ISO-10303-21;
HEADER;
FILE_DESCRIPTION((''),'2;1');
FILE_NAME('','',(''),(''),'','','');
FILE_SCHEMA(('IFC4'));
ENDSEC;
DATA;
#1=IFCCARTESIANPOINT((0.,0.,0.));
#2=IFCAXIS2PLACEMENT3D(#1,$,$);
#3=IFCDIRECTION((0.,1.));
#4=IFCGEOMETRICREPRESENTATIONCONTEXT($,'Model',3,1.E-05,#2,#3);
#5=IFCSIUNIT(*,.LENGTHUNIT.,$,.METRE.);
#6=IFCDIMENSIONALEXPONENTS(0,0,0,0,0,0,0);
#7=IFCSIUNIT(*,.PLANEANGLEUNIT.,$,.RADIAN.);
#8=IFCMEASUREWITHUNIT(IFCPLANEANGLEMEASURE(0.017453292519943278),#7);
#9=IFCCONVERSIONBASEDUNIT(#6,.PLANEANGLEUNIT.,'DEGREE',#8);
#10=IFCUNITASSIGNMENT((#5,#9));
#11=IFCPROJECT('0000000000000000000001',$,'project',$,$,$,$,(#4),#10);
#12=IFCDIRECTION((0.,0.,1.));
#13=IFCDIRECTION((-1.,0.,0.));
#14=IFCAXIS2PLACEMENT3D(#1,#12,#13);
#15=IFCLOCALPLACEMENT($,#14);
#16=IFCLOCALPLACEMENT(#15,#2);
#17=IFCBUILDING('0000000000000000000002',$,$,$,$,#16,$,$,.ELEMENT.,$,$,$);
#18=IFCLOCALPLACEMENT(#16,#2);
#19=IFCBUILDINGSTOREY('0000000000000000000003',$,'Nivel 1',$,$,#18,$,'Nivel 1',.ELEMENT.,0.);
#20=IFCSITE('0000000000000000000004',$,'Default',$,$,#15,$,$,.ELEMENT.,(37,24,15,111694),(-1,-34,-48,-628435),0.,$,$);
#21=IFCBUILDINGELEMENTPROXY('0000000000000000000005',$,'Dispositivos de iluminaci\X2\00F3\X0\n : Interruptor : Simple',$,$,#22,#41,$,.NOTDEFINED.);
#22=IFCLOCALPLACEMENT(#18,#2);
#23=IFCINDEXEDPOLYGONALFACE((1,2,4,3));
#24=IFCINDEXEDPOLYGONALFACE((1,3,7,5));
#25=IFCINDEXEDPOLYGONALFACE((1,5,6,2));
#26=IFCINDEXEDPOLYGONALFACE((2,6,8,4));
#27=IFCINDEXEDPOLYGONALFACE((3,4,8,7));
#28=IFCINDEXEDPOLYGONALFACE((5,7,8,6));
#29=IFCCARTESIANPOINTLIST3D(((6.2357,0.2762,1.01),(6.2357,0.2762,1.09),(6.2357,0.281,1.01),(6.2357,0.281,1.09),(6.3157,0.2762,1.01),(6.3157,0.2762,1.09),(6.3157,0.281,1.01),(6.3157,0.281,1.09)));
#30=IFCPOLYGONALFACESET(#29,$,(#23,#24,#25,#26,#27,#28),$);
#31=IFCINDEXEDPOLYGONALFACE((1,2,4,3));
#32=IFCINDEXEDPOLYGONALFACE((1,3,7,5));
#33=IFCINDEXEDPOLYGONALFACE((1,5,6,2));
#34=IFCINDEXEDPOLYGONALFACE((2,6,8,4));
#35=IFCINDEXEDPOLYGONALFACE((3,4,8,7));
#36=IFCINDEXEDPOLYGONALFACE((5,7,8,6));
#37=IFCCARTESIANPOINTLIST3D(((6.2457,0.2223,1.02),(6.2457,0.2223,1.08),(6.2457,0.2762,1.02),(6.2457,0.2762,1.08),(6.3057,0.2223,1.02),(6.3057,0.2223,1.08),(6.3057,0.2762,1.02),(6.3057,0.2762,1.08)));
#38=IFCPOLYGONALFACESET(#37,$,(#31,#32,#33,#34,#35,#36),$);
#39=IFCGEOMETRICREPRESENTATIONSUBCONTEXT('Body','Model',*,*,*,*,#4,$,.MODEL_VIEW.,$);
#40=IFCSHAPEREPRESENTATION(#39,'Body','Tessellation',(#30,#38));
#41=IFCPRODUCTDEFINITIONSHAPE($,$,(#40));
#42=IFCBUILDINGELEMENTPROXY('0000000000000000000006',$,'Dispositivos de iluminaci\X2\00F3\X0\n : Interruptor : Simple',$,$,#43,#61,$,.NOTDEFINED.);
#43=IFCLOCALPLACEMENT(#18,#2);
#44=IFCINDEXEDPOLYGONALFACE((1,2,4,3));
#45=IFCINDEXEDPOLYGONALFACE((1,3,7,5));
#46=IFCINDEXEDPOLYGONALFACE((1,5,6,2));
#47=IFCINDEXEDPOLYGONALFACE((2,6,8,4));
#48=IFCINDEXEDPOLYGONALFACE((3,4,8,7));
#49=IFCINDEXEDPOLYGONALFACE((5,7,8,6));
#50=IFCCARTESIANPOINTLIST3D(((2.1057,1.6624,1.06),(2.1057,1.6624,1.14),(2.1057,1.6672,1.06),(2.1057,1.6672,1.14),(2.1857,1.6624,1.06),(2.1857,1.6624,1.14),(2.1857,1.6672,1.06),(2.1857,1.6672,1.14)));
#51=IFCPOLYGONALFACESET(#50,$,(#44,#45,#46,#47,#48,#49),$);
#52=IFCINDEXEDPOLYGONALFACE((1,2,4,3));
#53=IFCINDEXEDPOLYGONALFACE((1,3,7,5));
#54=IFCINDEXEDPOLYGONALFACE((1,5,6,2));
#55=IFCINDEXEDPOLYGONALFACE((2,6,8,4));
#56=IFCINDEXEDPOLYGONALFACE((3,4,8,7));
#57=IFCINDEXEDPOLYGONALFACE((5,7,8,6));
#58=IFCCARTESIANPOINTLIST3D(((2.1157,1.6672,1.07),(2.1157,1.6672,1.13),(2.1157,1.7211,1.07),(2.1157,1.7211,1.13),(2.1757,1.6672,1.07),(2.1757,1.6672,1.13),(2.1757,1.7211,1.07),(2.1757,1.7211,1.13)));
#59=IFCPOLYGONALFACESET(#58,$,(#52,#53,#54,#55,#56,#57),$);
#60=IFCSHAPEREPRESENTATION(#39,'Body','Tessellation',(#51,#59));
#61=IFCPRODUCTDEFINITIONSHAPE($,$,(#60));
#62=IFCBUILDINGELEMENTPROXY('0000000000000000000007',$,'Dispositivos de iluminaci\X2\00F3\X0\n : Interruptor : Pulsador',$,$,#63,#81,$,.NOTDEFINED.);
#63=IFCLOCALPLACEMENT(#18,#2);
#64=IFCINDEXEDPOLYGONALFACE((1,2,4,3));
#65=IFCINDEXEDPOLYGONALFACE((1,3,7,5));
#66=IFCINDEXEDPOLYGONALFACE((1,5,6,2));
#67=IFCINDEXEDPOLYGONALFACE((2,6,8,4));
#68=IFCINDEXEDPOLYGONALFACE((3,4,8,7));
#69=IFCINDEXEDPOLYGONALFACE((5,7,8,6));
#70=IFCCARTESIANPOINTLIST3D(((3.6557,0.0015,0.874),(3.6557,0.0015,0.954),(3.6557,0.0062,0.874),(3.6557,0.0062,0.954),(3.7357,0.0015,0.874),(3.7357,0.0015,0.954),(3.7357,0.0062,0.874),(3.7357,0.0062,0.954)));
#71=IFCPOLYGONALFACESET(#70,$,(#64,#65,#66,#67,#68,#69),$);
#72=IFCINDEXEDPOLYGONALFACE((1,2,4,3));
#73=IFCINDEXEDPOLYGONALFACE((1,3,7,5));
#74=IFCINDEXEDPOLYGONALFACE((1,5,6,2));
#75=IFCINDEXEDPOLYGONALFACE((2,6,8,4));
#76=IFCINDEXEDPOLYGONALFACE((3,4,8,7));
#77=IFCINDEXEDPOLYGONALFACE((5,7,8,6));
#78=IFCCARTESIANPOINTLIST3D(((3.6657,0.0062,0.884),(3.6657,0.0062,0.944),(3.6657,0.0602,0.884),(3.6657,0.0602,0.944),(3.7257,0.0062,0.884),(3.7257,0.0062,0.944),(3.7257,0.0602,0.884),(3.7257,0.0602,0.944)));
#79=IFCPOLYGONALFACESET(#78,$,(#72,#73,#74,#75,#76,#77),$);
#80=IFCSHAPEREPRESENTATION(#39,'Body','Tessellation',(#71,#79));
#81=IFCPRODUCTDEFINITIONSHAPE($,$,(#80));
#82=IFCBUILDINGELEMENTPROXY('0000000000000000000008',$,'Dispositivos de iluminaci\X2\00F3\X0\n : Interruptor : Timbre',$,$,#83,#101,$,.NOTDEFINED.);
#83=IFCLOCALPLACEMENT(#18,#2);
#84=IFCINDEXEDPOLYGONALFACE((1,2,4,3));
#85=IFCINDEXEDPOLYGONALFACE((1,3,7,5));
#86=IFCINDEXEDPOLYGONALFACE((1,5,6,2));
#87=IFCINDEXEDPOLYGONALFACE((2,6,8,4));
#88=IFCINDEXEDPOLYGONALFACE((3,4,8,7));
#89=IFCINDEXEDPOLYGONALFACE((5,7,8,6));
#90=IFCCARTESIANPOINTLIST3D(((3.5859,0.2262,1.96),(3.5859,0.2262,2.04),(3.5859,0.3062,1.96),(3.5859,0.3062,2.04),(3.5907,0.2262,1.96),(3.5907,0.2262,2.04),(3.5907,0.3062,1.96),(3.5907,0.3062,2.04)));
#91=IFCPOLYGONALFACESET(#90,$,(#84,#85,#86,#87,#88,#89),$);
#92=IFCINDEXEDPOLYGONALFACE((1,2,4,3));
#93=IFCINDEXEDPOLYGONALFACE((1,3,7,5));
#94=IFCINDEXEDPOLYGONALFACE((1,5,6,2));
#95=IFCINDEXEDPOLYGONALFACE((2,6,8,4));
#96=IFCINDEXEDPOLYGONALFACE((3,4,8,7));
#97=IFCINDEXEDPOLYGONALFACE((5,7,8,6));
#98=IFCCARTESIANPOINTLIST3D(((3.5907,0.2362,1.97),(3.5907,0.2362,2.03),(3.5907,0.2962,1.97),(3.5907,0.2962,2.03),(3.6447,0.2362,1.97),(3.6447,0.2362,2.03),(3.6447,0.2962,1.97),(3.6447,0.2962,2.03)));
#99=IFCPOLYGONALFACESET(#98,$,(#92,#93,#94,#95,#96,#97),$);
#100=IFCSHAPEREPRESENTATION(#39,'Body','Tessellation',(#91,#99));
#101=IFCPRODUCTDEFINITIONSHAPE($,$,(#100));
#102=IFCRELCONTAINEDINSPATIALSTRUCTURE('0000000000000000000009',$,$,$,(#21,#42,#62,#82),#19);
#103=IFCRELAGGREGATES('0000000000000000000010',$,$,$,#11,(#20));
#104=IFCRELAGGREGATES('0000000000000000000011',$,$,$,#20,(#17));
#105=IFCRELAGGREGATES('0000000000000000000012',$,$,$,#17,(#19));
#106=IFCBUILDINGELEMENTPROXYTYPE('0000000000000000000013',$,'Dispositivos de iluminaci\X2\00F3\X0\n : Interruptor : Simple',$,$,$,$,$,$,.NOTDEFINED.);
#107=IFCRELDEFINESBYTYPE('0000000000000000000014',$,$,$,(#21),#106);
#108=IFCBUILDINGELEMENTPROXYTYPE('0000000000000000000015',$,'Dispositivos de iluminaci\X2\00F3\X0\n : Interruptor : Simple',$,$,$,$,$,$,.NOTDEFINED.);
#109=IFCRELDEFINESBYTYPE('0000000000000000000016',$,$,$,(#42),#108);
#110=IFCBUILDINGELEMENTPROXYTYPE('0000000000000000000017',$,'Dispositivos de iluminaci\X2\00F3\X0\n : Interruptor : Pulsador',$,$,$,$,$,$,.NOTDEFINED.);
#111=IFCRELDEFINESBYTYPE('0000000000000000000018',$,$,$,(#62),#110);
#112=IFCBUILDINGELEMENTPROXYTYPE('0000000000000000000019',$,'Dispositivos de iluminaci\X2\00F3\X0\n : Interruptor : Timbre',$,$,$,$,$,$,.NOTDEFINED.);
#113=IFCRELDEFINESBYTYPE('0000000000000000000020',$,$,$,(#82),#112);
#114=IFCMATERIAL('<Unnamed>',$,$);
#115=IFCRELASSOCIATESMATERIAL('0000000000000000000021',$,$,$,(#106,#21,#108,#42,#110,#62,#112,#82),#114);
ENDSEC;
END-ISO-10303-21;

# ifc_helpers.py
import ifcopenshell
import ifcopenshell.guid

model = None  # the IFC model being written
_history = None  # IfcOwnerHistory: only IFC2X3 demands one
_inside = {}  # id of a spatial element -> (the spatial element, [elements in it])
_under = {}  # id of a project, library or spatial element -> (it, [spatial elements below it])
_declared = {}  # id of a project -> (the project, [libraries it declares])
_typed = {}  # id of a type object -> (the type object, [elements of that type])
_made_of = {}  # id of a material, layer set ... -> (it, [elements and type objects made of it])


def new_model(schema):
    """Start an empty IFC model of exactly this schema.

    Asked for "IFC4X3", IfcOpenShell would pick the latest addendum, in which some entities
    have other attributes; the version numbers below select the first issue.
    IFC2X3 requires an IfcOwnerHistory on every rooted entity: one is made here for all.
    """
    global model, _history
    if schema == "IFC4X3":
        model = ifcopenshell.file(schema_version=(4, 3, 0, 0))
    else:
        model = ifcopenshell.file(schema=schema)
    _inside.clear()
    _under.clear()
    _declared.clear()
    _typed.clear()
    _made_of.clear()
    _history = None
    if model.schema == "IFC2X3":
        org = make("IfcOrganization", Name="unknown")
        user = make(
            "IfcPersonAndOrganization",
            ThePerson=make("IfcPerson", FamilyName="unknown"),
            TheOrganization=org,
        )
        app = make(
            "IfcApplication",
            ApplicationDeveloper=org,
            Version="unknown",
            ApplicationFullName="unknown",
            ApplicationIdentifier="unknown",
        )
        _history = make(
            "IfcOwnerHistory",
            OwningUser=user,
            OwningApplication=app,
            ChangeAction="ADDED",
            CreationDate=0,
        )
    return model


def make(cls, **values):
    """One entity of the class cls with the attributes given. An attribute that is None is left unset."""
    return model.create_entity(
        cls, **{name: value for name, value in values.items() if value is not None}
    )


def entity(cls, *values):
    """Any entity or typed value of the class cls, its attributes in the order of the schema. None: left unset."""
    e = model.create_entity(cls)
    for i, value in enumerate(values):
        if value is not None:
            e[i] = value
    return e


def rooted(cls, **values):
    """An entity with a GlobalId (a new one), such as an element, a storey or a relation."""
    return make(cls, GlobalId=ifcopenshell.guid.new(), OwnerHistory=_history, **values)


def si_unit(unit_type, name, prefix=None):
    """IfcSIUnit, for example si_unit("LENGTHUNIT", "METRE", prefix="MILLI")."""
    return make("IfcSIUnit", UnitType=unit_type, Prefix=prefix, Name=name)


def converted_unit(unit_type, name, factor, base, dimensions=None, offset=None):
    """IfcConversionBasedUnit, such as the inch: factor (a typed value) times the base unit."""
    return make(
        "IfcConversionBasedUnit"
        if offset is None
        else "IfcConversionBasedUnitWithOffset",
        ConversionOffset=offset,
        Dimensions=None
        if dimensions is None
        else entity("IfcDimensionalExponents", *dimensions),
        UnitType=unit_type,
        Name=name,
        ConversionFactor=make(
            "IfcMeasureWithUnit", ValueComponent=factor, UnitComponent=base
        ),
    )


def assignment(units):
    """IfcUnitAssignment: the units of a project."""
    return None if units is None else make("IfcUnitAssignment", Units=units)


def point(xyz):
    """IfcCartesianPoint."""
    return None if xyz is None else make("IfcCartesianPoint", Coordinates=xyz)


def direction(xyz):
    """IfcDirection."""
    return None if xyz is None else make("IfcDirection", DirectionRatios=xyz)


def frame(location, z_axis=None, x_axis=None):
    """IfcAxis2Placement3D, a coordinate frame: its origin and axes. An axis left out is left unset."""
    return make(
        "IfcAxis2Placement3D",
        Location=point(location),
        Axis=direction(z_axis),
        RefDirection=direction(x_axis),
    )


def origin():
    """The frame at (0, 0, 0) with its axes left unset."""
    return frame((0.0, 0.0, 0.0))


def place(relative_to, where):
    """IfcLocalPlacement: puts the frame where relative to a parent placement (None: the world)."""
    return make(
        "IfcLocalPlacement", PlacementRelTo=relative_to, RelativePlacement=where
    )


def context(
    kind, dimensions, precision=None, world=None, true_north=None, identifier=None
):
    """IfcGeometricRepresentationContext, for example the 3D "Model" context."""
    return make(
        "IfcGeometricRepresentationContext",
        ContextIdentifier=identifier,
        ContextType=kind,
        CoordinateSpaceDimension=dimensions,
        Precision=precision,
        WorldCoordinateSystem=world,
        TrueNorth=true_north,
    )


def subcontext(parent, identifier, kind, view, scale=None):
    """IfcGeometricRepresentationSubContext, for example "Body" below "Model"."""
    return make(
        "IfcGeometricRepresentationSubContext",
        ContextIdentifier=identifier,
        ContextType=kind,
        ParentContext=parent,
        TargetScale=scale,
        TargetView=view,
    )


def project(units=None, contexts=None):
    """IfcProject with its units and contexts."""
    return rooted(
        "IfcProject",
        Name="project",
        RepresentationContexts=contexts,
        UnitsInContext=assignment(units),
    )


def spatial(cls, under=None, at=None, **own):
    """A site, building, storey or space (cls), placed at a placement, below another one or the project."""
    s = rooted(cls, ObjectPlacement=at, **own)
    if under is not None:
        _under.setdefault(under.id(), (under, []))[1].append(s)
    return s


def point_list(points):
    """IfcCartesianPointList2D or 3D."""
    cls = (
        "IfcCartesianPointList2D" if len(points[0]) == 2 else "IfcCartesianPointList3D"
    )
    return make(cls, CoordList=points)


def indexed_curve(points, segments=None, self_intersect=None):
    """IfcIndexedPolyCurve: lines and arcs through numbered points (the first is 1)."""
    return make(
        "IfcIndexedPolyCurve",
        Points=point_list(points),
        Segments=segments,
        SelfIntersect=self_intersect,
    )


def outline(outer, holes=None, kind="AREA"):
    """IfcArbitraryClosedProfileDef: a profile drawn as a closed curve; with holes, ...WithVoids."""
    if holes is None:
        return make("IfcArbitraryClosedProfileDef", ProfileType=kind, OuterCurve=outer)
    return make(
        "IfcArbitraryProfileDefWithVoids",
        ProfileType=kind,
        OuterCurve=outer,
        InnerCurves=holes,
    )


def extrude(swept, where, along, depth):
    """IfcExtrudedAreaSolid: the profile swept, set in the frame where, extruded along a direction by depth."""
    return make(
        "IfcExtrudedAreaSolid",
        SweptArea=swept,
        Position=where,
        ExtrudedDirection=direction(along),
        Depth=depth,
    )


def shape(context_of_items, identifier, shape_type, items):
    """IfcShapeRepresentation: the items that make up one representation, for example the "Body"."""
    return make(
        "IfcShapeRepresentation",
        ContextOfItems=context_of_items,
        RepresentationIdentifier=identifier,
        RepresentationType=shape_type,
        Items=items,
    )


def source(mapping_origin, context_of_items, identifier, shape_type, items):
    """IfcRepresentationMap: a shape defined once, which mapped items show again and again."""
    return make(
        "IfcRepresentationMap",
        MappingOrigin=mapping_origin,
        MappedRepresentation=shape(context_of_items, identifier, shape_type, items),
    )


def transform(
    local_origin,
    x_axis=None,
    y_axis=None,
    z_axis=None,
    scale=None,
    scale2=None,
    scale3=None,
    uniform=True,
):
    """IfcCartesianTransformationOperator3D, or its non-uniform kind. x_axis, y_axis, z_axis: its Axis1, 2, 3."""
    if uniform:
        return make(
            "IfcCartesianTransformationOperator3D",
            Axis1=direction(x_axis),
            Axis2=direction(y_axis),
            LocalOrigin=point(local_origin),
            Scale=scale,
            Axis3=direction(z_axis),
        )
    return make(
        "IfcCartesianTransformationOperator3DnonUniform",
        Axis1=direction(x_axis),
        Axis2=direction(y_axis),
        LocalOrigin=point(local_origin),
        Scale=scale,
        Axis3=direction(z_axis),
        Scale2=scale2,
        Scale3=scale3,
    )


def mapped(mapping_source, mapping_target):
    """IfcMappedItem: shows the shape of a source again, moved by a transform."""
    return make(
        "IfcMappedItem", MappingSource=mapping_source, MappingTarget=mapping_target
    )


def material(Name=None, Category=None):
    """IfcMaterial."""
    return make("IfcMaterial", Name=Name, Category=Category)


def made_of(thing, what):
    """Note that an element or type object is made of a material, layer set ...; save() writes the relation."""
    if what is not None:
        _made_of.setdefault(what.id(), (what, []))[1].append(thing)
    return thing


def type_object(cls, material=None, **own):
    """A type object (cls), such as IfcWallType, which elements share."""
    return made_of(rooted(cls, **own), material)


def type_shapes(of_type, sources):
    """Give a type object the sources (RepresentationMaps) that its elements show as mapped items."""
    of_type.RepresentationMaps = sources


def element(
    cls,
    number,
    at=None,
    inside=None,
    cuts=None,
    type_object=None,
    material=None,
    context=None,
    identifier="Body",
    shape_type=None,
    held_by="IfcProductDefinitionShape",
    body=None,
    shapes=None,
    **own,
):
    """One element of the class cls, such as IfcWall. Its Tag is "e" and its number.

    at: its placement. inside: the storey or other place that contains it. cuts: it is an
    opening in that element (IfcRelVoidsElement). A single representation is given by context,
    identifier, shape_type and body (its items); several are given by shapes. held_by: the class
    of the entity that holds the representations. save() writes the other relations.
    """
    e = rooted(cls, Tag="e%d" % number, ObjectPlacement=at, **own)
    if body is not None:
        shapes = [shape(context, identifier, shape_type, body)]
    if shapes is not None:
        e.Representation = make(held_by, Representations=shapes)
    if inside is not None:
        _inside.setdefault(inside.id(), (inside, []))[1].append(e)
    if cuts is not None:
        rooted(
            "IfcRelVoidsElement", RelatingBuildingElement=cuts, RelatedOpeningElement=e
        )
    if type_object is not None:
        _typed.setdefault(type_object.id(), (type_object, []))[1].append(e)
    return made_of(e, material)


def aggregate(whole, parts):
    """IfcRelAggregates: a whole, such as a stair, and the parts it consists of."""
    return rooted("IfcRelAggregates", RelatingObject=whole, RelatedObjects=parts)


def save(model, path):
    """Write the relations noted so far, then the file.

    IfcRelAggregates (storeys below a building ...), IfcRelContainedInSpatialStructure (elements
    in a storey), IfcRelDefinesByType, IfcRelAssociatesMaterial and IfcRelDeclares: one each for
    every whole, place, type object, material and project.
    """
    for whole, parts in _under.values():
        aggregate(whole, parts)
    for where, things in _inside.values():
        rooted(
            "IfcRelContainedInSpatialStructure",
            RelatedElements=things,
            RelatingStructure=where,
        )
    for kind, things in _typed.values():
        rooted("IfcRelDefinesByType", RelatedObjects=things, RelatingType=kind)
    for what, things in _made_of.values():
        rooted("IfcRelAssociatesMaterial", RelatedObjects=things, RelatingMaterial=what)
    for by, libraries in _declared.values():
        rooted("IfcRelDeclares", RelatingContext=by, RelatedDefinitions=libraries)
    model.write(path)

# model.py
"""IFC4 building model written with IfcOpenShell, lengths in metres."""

from ifc_helpers import new_model, entity, si_unit, converted_unit, direction, frame, origin, place, context, subcontext, project, spatial, indexed_curve, outline, extrude, source, transform, mapped, material, type_object, type_shapes, element, save


model = new_model("IFC4")

# Units and contexts
model_context = context("Model", 3, precision=1e-05, world=origin(), true_north=direction((0.0, 1.0)))
body_context = subcontext(model_context, "Body", "Model", "MODEL_VIEW")
ifc_project = project(units=[si_unit("LENGTHUNIT", "METRE"), converted_unit("PLANEANGLEUNIT", "DEGREE", entity("IfcPlaneAngleMeasure", 0.017453292519943278), si_unit("PLANEANGLEUNIT", "RADIAN"), dimensions=[0, 0, 0, 0, 0, 0, 0])], contexts=[model_context])

# Site, building, storey
site_placement = place(None, frame((0.0, 0.0, 0.0), z_axis=(0.0, 0.0, 1.0), x_axis=(-1.0, 0.0, 0.0)))
site = spatial("IfcSite", under=ifc_project, at=site_placement, Name="Default", CompositionType="ELEMENT", RefLatitude=(37, 24, 15, 111694), RefLongitude=(-1, -34, -48, -628435), RefElevation=0.0)
building_placement = place(site_placement, origin())
building = spatial("IfcBuilding", under=site, at=building_placement, CompositionType="ELEMENT")
storey_placement = place(building_placement, origin())
storey = spatial("IfcBuildingStorey", under=building, at=storey_placement, Name="Nivel 1", LongName="Nivel 1", CompositionType="ELEMENT", Elevation=0.0)

# Shared definitions
ifc_material_1 = material(Name="<Unnamed>")

# Building element proxies
building_element_proxy_type_1 = type_object("IfcBuildingElementProxyType", Name="Dispositivos de iluminación : Interruptor : Simple", PredefinedType="NOTDEFINED", material=ifc_material_1)
shared_shape_1 = source(origin(), body_context, "Body", "SweptSolid", [
    extrude(outline(indexed_curve([(-0.04, -0.04), (0.04, -0.04), (0.04, 0.04), (-0.04, 0.04), (-0.04, -0.04)], self_intersect=False)), frame((0.0, 0.0, 0.0), z_axis=(0.0, 0.0, 1.0), x_axis=(0.0, -1.0, 0.0)), (0.0, 0.0, 1.0), 0.0048),
    extrude(outline(indexed_curve([(-0.03, -0.03), (0.03, -0.03), (0.03, 0.03), (-0.03, 0.03), (-0.03, -0.03)], self_intersect=False)), frame((0.0, 0.0, -0.054), z_axis=(0.0, 0.0, 1.0), x_axis=(-1.0, 0.0, 0.0)), (0.0, 0.0, 1.0), 0.054),
])
type_shapes(building_element_proxy_type_1, [shared_shape_1])
for number, where, z_axis, x_axis, name in (
    (1, (6.2757, 0.2762, 1.05), (0.0, 1.0, 0.0), (0.0, 0.0, -1.0), "Dispositivos de iluminación : Interruptor : Simple"),
):
    element("IfcBuildingElementProxy", number, at=place(storey_placement, frame(where, z_axis=z_axis, x_axis=x_axis)), inside=storey, type_object=building_element_proxy_type_1, material=ifc_material_1, Name=name, PredefinedType="NOTDEFINED", context=body_context, shape_type="MappedRepresentation", body=[
        mapped(shared_shape_1, transform((0.0, 0.0, 0.0), scale=1.0)),
    ])
building_element_proxy_type_2 = type_object("IfcBuildingElementProxyType", Name="Dispositivos de iluminación : Interruptor : Simple", PredefinedType="NOTDEFINED", material=ifc_material_1)
shared_shape_2 = source(origin(), body_context, "Body", "SweptSolid", [
    extrude(outline(indexed_curve([(-0.04, -0.04), (0.04, -0.04), (0.04, 0.04), (-0.04, 0.04), (-0.04, -0.04)], self_intersect=False)), frame((0.0, 0.0, 0.0), z_axis=(0.0, 0.0, 1.0), x_axis=(0.0, -1.0, 0.0)), (0.0, 0.0, 1.0), 0.0048),
    extrude(outline(indexed_curve([(-0.03, -0.03), (0.03, -0.03), (0.03, 0.03), (-0.03, 0.03), (-0.03, -0.03)], self_intersect=False)), frame((0.0, 0.0, -0.054), z_axis=(0.0, 0.0, 1.0), x_axis=(-1.0, 0.0, 0.0)), (0.0, 0.0, 1.0), 0.054),
])
type_shapes(building_element_proxy_type_2, [shared_shape_2])
proxy_1_placement = place(storey_placement, frame((2.1457, 1.6672, 1.1), z_axis=(0.0, -1.0, 0.0), x_axis=(1.0, 0.0, 0.0)))
element("IfcBuildingElementProxy", 2, at=proxy_1_placement, inside=storey, type_object=building_element_proxy_type_2, material=ifc_material_1, Name="Dispositivos de iluminación : Interruptor : Simple", PredefinedType="NOTDEFINED", context=body_context, shape_type="MappedRepresentation", body=[
    mapped(shared_shape_2, transform((0.0, 0.0, 0.0), scale=1.0)),
])
building_element_proxy_type_3 = type_object("IfcBuildingElementProxyType", Name="Dispositivos de iluminación : Interruptor : Pulsador", PredefinedType="NOTDEFINED", material=ifc_material_1)
shared_shape_3 = source(origin(), body_context, "Body", "SweptSolid", [
    extrude(outline(indexed_curve([(-0.04, -0.04), (0.04, -0.04), (0.04, 0.04), (-0.04, 0.04), (-0.04, -0.04)], self_intersect=False)), frame((0.0, 0.0, 0.0), z_axis=(0.0, 0.0, 1.0), x_axis=(0.0, -1.0, 0.0)), (0.0, 0.0, 1.0), 0.0048),
    extrude(outline(indexed_curve([(-0.03, -0.03), (0.03, -0.03), (0.03, 0.03), (-0.03, 0.03), (-0.03, -0.03)], self_intersect=False)), frame((0.0, 0.0, -0.054), z_axis=(0.0, 0.0, 1.0), x_axis=(-1.0, 0.0, 0.0)), (0.0, 0.0, 1.0), 0.054),
])
type_shapes(building_element_proxy_type_3, [shared_shape_3])
proxy_2_placement = place(storey_placement, frame((3.6957, 0.0062, 0.914), z_axis=(0.0, -1.0, 0.0), x_axis=(1.0, 0.0, 0.0)))
element("IfcBuildingElementProxy", 3, at=proxy_2_placement, inside=storey, type_object=building_element_proxy_type_3, material=ifc_material_1, Name="Dispositivos de iluminación : Interruptor : Pulsador", PredefinedType="NOTDEFINED", context=body_context, shape_type="MappedRepresentation", body=[
    mapped(shared_shape_3, transform((0.0, 0.0, 0.0), scale=1.0)),
])
building_element_proxy_type_4 = type_object("IfcBuildingElementProxyType", Name="Dispositivos de iluminación : Interruptor : Timbre", PredefinedType="NOTDEFINED", material=ifc_material_1)
shared_shape_4 = source(origin(), body_context, "Body", "SweptSolid", [
    extrude(outline(indexed_curve([(-0.04, -0.04), (0.04, -0.04), (0.04, 0.04), (-0.04, 0.04), (-0.04, -0.04)], self_intersect=False)), frame((0.0, 0.0, 0.0), z_axis=(0.0, 0.0, 1.0), x_axis=(0.0, -1.0, 0.0)), (0.0, 0.0, 1.0), 0.0048),
    extrude(outline(indexed_curve([(-0.03, -0.03), (0.03, -0.03), (0.03, 0.03), (-0.03, 0.03), (-0.03, -0.03)], self_intersect=False)), frame((0.0, 0.0, -0.054), z_axis=(0.0, 0.0, 1.0), x_axis=(-1.0, 0.0, 0.0)), (0.0, 0.0, 1.0), 0.054),
])
type_shapes(building_element_proxy_type_4, [shared_shape_4])
proxy_3_placement = place(storey_placement, frame((3.5907, 0.2662, 2.0), z_axis=(-1.0, 0.0, 0.0), x_axis=(0.0, 0.0, 1.0)))
element("IfcBuildingElementProxy", 4, at=proxy_3_placement, inside=storey, type_object=building_element_proxy_type_4, material=ifc_material_1, Name="Dispositivos de iluminación : Interruptor : Timbre", PredefinedType="NOTDEFINED", context=body_context, shape_type="MappedRepresentation", body=[
    mapped(shared_shape_4, transform((0.0, 0.0, 0.0), scale=1.0)),
])

save(model, "model.ifc")
